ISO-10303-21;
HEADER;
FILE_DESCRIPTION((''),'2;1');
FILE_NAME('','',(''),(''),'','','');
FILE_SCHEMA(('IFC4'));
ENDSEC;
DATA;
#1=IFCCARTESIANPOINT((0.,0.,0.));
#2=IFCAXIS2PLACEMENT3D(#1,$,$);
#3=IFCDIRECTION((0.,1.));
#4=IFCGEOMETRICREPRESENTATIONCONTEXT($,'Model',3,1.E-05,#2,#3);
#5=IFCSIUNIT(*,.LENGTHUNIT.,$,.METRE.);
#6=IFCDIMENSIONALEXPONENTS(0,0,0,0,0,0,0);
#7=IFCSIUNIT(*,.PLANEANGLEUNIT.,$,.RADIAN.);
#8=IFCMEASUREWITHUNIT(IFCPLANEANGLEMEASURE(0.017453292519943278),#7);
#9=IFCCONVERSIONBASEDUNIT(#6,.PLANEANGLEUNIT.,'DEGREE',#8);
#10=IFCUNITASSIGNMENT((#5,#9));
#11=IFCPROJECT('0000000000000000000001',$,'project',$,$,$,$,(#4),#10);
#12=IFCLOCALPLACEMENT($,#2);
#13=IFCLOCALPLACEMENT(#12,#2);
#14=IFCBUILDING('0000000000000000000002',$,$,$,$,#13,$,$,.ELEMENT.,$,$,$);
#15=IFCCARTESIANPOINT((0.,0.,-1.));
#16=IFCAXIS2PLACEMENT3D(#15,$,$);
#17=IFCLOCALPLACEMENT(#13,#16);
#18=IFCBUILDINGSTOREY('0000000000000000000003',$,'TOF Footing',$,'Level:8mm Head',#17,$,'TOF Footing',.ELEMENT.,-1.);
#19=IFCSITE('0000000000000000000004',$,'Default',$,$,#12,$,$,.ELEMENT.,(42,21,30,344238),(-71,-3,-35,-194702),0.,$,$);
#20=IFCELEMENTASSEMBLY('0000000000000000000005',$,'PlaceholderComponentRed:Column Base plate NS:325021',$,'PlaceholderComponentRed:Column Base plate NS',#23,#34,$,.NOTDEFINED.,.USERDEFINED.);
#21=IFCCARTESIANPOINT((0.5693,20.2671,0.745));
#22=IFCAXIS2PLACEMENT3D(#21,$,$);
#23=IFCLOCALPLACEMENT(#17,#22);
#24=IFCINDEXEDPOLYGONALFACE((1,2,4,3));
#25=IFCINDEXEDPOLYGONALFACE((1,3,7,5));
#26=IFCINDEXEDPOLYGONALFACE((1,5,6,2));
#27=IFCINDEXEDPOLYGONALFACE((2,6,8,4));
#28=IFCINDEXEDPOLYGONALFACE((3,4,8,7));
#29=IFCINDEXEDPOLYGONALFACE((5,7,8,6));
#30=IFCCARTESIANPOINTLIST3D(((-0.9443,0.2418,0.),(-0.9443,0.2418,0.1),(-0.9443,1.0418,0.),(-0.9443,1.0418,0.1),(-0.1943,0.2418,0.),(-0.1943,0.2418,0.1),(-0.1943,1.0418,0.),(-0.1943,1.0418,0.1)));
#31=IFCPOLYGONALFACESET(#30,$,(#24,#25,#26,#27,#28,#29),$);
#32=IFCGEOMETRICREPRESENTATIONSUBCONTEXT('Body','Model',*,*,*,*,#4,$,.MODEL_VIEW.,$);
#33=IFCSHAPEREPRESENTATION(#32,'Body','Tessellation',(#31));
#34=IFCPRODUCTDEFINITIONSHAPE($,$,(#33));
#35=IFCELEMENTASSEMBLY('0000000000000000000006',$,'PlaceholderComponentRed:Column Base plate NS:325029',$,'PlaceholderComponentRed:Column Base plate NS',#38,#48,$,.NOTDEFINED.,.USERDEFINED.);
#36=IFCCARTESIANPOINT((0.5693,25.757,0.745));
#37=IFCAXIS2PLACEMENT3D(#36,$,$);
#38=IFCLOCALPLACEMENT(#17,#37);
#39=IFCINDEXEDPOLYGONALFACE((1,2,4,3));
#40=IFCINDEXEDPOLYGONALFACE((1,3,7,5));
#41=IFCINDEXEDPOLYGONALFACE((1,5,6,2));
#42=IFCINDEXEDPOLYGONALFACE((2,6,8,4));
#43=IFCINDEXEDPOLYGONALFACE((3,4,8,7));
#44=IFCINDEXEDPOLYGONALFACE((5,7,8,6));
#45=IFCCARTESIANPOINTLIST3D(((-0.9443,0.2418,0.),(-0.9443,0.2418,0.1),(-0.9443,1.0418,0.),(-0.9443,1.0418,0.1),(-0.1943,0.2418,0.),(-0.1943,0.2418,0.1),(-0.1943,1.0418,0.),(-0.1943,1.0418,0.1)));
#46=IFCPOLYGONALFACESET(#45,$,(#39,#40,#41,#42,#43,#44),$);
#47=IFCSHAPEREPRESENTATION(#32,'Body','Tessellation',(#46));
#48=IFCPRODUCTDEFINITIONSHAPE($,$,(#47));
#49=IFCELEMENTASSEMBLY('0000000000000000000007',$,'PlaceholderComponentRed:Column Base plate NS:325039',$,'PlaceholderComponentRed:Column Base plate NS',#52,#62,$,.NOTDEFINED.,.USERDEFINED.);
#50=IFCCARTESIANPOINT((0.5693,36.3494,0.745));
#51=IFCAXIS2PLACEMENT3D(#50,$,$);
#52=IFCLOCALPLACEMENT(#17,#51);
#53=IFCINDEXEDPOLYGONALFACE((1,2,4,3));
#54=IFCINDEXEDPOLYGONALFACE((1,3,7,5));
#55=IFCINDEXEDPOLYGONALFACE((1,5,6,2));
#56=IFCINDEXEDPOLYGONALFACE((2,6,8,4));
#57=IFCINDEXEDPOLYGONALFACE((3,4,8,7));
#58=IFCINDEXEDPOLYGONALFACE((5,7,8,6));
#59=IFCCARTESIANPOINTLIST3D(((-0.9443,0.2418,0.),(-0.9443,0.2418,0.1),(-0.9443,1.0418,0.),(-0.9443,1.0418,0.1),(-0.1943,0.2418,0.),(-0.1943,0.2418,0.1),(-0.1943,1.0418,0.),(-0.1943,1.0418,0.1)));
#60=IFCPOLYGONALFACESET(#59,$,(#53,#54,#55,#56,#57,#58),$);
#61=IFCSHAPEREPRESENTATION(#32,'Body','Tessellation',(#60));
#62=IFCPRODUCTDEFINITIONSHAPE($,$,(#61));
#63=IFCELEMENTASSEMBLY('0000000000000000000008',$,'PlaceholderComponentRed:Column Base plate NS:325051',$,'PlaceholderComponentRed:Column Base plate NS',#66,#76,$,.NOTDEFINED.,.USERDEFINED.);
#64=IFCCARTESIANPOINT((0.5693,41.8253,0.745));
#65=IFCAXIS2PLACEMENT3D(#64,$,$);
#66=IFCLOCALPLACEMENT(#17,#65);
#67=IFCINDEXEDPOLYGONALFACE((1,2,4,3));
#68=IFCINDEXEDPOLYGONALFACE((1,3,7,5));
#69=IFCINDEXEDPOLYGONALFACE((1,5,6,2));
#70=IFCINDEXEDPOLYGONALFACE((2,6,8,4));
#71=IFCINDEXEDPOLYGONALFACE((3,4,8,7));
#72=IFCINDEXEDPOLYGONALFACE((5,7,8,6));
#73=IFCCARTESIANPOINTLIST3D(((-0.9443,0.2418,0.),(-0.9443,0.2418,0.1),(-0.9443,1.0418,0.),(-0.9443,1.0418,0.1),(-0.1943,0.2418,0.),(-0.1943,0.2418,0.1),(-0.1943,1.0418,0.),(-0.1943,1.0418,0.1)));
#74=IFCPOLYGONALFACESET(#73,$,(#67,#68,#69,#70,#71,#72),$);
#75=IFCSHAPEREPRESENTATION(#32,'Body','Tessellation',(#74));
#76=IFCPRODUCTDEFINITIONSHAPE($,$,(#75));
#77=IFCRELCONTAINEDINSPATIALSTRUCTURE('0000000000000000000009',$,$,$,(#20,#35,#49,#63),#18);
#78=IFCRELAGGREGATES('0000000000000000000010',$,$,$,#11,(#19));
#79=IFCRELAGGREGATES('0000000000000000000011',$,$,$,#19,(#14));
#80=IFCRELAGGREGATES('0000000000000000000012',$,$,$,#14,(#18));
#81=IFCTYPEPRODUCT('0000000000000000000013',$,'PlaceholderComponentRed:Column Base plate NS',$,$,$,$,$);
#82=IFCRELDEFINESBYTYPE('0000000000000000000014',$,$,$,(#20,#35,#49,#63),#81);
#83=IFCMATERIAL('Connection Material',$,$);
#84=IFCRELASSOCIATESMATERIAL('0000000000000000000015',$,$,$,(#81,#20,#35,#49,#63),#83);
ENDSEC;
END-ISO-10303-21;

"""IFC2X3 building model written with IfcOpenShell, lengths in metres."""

from ifc_helpers import new_model, entity, si_unit, converted_unit, direction, frame, frame_2d, origin, place, context, subcontext, project, spatial, rectangle, extrude, source, transform, mapped, material, type_object, type_shapes, element, save


model = new_model("IFC2X3")

# Units and contexts
model_context = context("Model", 3, precision=1e-05, world=origin(), true_north=direction((0.0, 1.0)))
body_context = subcontext(model_context, "Body", "Model", "MODEL_VIEW")
ifc_project = project(units=[si_unit("LENGTHUNIT", "METRE"), converted_unit("PLANEANGLEUNIT", "DEGREE", entity("IfcPlaneAngleMeasure", 0.017453292519943278), si_unit("PLANEANGLEUNIT", "RADIAN"), dimensions=[0, 0, 0, 0, 0, 0, 0])], contexts=[model_context])

# Site, building, storey
site_placement = place(None, origin())
site = spatial("IfcSite", under=ifc_project, at=site_placement, Name="Default", CompositionType="ELEMENT", RefLatitude=(42, 21, 30, 344238), RefLongitude=(-71, -3, -35, -194702), RefElevation=0.0)
building_placement = place(site_placement, origin())
building = spatial("IfcBuilding", under=site, at=building_placement, CompositionType="ELEMENT")
storey_placement = place(building_placement, frame((0.0, 0.0, -1.0)))
storey = spatial("IfcBuildingStorey", under=building, at=storey_placement, Name="TOF Footing", ObjectType="Level:8mm Head", LongName="TOF Footing", CompositionType="ELEMENT", Elevation=-1.0)

# Element assemblies
ifc_material_1 = material(Name="Connection Material")
type_product = type_object("IfcTypeProduct", Name="PlaceholderComponentRed:Column Base plate NS", material=ifc_material_1)
shared_shape_1 = source(origin(), body_context, "Body", "SweptSolid", [
    extrude(rectangle(XDim=0.8, YDim=0.75, at=frame_2d((0.0, 0.0), x_axis=(1.0, 0.0))), frame((-0.5693, 0.6418, 0.0), z_axis=(0.0, 0.0, 1.0), x_axis=(0.0, 1.0, 0.0)), (0.0, 0.0, 1.0), 0.1),
])
type_shapes(type_product, [shared_shape_1])
for number, where, name in (
    (1, (0.5693, 20.2671, 0.745), "PlaceholderComponentRed:Column Base plate NS:325021"),
    (2, (0.5693, 25.757, 0.745), "PlaceholderComponentRed:Column Base plate NS:325029"),
    (3, (0.5693, 36.3494, 0.745), "PlaceholderComponentRed:Column Base plate NS:325039"),
    (4, (0.5693, 41.8253, 0.745), "PlaceholderComponentRed:Column Base plate NS:325051"),
):
    element("IfcElementAssembly", number, at=place(storey_placement, frame(where)), inside=storey, type_object=type_product, material=ifc_material_1, Name=name, ObjectType="PlaceholderComponentRed:Column Base plate NS", AssemblyPlace="NOTDEFINED", PredefinedType="USERDEFINED", context=body_context, shape_type="MappedRepresentation", body=[
        mapped(shared_shape_1, transform((0.0, 0.0, 0.0), scale=1.0)),
    ])

save(model, "model.ifc")
